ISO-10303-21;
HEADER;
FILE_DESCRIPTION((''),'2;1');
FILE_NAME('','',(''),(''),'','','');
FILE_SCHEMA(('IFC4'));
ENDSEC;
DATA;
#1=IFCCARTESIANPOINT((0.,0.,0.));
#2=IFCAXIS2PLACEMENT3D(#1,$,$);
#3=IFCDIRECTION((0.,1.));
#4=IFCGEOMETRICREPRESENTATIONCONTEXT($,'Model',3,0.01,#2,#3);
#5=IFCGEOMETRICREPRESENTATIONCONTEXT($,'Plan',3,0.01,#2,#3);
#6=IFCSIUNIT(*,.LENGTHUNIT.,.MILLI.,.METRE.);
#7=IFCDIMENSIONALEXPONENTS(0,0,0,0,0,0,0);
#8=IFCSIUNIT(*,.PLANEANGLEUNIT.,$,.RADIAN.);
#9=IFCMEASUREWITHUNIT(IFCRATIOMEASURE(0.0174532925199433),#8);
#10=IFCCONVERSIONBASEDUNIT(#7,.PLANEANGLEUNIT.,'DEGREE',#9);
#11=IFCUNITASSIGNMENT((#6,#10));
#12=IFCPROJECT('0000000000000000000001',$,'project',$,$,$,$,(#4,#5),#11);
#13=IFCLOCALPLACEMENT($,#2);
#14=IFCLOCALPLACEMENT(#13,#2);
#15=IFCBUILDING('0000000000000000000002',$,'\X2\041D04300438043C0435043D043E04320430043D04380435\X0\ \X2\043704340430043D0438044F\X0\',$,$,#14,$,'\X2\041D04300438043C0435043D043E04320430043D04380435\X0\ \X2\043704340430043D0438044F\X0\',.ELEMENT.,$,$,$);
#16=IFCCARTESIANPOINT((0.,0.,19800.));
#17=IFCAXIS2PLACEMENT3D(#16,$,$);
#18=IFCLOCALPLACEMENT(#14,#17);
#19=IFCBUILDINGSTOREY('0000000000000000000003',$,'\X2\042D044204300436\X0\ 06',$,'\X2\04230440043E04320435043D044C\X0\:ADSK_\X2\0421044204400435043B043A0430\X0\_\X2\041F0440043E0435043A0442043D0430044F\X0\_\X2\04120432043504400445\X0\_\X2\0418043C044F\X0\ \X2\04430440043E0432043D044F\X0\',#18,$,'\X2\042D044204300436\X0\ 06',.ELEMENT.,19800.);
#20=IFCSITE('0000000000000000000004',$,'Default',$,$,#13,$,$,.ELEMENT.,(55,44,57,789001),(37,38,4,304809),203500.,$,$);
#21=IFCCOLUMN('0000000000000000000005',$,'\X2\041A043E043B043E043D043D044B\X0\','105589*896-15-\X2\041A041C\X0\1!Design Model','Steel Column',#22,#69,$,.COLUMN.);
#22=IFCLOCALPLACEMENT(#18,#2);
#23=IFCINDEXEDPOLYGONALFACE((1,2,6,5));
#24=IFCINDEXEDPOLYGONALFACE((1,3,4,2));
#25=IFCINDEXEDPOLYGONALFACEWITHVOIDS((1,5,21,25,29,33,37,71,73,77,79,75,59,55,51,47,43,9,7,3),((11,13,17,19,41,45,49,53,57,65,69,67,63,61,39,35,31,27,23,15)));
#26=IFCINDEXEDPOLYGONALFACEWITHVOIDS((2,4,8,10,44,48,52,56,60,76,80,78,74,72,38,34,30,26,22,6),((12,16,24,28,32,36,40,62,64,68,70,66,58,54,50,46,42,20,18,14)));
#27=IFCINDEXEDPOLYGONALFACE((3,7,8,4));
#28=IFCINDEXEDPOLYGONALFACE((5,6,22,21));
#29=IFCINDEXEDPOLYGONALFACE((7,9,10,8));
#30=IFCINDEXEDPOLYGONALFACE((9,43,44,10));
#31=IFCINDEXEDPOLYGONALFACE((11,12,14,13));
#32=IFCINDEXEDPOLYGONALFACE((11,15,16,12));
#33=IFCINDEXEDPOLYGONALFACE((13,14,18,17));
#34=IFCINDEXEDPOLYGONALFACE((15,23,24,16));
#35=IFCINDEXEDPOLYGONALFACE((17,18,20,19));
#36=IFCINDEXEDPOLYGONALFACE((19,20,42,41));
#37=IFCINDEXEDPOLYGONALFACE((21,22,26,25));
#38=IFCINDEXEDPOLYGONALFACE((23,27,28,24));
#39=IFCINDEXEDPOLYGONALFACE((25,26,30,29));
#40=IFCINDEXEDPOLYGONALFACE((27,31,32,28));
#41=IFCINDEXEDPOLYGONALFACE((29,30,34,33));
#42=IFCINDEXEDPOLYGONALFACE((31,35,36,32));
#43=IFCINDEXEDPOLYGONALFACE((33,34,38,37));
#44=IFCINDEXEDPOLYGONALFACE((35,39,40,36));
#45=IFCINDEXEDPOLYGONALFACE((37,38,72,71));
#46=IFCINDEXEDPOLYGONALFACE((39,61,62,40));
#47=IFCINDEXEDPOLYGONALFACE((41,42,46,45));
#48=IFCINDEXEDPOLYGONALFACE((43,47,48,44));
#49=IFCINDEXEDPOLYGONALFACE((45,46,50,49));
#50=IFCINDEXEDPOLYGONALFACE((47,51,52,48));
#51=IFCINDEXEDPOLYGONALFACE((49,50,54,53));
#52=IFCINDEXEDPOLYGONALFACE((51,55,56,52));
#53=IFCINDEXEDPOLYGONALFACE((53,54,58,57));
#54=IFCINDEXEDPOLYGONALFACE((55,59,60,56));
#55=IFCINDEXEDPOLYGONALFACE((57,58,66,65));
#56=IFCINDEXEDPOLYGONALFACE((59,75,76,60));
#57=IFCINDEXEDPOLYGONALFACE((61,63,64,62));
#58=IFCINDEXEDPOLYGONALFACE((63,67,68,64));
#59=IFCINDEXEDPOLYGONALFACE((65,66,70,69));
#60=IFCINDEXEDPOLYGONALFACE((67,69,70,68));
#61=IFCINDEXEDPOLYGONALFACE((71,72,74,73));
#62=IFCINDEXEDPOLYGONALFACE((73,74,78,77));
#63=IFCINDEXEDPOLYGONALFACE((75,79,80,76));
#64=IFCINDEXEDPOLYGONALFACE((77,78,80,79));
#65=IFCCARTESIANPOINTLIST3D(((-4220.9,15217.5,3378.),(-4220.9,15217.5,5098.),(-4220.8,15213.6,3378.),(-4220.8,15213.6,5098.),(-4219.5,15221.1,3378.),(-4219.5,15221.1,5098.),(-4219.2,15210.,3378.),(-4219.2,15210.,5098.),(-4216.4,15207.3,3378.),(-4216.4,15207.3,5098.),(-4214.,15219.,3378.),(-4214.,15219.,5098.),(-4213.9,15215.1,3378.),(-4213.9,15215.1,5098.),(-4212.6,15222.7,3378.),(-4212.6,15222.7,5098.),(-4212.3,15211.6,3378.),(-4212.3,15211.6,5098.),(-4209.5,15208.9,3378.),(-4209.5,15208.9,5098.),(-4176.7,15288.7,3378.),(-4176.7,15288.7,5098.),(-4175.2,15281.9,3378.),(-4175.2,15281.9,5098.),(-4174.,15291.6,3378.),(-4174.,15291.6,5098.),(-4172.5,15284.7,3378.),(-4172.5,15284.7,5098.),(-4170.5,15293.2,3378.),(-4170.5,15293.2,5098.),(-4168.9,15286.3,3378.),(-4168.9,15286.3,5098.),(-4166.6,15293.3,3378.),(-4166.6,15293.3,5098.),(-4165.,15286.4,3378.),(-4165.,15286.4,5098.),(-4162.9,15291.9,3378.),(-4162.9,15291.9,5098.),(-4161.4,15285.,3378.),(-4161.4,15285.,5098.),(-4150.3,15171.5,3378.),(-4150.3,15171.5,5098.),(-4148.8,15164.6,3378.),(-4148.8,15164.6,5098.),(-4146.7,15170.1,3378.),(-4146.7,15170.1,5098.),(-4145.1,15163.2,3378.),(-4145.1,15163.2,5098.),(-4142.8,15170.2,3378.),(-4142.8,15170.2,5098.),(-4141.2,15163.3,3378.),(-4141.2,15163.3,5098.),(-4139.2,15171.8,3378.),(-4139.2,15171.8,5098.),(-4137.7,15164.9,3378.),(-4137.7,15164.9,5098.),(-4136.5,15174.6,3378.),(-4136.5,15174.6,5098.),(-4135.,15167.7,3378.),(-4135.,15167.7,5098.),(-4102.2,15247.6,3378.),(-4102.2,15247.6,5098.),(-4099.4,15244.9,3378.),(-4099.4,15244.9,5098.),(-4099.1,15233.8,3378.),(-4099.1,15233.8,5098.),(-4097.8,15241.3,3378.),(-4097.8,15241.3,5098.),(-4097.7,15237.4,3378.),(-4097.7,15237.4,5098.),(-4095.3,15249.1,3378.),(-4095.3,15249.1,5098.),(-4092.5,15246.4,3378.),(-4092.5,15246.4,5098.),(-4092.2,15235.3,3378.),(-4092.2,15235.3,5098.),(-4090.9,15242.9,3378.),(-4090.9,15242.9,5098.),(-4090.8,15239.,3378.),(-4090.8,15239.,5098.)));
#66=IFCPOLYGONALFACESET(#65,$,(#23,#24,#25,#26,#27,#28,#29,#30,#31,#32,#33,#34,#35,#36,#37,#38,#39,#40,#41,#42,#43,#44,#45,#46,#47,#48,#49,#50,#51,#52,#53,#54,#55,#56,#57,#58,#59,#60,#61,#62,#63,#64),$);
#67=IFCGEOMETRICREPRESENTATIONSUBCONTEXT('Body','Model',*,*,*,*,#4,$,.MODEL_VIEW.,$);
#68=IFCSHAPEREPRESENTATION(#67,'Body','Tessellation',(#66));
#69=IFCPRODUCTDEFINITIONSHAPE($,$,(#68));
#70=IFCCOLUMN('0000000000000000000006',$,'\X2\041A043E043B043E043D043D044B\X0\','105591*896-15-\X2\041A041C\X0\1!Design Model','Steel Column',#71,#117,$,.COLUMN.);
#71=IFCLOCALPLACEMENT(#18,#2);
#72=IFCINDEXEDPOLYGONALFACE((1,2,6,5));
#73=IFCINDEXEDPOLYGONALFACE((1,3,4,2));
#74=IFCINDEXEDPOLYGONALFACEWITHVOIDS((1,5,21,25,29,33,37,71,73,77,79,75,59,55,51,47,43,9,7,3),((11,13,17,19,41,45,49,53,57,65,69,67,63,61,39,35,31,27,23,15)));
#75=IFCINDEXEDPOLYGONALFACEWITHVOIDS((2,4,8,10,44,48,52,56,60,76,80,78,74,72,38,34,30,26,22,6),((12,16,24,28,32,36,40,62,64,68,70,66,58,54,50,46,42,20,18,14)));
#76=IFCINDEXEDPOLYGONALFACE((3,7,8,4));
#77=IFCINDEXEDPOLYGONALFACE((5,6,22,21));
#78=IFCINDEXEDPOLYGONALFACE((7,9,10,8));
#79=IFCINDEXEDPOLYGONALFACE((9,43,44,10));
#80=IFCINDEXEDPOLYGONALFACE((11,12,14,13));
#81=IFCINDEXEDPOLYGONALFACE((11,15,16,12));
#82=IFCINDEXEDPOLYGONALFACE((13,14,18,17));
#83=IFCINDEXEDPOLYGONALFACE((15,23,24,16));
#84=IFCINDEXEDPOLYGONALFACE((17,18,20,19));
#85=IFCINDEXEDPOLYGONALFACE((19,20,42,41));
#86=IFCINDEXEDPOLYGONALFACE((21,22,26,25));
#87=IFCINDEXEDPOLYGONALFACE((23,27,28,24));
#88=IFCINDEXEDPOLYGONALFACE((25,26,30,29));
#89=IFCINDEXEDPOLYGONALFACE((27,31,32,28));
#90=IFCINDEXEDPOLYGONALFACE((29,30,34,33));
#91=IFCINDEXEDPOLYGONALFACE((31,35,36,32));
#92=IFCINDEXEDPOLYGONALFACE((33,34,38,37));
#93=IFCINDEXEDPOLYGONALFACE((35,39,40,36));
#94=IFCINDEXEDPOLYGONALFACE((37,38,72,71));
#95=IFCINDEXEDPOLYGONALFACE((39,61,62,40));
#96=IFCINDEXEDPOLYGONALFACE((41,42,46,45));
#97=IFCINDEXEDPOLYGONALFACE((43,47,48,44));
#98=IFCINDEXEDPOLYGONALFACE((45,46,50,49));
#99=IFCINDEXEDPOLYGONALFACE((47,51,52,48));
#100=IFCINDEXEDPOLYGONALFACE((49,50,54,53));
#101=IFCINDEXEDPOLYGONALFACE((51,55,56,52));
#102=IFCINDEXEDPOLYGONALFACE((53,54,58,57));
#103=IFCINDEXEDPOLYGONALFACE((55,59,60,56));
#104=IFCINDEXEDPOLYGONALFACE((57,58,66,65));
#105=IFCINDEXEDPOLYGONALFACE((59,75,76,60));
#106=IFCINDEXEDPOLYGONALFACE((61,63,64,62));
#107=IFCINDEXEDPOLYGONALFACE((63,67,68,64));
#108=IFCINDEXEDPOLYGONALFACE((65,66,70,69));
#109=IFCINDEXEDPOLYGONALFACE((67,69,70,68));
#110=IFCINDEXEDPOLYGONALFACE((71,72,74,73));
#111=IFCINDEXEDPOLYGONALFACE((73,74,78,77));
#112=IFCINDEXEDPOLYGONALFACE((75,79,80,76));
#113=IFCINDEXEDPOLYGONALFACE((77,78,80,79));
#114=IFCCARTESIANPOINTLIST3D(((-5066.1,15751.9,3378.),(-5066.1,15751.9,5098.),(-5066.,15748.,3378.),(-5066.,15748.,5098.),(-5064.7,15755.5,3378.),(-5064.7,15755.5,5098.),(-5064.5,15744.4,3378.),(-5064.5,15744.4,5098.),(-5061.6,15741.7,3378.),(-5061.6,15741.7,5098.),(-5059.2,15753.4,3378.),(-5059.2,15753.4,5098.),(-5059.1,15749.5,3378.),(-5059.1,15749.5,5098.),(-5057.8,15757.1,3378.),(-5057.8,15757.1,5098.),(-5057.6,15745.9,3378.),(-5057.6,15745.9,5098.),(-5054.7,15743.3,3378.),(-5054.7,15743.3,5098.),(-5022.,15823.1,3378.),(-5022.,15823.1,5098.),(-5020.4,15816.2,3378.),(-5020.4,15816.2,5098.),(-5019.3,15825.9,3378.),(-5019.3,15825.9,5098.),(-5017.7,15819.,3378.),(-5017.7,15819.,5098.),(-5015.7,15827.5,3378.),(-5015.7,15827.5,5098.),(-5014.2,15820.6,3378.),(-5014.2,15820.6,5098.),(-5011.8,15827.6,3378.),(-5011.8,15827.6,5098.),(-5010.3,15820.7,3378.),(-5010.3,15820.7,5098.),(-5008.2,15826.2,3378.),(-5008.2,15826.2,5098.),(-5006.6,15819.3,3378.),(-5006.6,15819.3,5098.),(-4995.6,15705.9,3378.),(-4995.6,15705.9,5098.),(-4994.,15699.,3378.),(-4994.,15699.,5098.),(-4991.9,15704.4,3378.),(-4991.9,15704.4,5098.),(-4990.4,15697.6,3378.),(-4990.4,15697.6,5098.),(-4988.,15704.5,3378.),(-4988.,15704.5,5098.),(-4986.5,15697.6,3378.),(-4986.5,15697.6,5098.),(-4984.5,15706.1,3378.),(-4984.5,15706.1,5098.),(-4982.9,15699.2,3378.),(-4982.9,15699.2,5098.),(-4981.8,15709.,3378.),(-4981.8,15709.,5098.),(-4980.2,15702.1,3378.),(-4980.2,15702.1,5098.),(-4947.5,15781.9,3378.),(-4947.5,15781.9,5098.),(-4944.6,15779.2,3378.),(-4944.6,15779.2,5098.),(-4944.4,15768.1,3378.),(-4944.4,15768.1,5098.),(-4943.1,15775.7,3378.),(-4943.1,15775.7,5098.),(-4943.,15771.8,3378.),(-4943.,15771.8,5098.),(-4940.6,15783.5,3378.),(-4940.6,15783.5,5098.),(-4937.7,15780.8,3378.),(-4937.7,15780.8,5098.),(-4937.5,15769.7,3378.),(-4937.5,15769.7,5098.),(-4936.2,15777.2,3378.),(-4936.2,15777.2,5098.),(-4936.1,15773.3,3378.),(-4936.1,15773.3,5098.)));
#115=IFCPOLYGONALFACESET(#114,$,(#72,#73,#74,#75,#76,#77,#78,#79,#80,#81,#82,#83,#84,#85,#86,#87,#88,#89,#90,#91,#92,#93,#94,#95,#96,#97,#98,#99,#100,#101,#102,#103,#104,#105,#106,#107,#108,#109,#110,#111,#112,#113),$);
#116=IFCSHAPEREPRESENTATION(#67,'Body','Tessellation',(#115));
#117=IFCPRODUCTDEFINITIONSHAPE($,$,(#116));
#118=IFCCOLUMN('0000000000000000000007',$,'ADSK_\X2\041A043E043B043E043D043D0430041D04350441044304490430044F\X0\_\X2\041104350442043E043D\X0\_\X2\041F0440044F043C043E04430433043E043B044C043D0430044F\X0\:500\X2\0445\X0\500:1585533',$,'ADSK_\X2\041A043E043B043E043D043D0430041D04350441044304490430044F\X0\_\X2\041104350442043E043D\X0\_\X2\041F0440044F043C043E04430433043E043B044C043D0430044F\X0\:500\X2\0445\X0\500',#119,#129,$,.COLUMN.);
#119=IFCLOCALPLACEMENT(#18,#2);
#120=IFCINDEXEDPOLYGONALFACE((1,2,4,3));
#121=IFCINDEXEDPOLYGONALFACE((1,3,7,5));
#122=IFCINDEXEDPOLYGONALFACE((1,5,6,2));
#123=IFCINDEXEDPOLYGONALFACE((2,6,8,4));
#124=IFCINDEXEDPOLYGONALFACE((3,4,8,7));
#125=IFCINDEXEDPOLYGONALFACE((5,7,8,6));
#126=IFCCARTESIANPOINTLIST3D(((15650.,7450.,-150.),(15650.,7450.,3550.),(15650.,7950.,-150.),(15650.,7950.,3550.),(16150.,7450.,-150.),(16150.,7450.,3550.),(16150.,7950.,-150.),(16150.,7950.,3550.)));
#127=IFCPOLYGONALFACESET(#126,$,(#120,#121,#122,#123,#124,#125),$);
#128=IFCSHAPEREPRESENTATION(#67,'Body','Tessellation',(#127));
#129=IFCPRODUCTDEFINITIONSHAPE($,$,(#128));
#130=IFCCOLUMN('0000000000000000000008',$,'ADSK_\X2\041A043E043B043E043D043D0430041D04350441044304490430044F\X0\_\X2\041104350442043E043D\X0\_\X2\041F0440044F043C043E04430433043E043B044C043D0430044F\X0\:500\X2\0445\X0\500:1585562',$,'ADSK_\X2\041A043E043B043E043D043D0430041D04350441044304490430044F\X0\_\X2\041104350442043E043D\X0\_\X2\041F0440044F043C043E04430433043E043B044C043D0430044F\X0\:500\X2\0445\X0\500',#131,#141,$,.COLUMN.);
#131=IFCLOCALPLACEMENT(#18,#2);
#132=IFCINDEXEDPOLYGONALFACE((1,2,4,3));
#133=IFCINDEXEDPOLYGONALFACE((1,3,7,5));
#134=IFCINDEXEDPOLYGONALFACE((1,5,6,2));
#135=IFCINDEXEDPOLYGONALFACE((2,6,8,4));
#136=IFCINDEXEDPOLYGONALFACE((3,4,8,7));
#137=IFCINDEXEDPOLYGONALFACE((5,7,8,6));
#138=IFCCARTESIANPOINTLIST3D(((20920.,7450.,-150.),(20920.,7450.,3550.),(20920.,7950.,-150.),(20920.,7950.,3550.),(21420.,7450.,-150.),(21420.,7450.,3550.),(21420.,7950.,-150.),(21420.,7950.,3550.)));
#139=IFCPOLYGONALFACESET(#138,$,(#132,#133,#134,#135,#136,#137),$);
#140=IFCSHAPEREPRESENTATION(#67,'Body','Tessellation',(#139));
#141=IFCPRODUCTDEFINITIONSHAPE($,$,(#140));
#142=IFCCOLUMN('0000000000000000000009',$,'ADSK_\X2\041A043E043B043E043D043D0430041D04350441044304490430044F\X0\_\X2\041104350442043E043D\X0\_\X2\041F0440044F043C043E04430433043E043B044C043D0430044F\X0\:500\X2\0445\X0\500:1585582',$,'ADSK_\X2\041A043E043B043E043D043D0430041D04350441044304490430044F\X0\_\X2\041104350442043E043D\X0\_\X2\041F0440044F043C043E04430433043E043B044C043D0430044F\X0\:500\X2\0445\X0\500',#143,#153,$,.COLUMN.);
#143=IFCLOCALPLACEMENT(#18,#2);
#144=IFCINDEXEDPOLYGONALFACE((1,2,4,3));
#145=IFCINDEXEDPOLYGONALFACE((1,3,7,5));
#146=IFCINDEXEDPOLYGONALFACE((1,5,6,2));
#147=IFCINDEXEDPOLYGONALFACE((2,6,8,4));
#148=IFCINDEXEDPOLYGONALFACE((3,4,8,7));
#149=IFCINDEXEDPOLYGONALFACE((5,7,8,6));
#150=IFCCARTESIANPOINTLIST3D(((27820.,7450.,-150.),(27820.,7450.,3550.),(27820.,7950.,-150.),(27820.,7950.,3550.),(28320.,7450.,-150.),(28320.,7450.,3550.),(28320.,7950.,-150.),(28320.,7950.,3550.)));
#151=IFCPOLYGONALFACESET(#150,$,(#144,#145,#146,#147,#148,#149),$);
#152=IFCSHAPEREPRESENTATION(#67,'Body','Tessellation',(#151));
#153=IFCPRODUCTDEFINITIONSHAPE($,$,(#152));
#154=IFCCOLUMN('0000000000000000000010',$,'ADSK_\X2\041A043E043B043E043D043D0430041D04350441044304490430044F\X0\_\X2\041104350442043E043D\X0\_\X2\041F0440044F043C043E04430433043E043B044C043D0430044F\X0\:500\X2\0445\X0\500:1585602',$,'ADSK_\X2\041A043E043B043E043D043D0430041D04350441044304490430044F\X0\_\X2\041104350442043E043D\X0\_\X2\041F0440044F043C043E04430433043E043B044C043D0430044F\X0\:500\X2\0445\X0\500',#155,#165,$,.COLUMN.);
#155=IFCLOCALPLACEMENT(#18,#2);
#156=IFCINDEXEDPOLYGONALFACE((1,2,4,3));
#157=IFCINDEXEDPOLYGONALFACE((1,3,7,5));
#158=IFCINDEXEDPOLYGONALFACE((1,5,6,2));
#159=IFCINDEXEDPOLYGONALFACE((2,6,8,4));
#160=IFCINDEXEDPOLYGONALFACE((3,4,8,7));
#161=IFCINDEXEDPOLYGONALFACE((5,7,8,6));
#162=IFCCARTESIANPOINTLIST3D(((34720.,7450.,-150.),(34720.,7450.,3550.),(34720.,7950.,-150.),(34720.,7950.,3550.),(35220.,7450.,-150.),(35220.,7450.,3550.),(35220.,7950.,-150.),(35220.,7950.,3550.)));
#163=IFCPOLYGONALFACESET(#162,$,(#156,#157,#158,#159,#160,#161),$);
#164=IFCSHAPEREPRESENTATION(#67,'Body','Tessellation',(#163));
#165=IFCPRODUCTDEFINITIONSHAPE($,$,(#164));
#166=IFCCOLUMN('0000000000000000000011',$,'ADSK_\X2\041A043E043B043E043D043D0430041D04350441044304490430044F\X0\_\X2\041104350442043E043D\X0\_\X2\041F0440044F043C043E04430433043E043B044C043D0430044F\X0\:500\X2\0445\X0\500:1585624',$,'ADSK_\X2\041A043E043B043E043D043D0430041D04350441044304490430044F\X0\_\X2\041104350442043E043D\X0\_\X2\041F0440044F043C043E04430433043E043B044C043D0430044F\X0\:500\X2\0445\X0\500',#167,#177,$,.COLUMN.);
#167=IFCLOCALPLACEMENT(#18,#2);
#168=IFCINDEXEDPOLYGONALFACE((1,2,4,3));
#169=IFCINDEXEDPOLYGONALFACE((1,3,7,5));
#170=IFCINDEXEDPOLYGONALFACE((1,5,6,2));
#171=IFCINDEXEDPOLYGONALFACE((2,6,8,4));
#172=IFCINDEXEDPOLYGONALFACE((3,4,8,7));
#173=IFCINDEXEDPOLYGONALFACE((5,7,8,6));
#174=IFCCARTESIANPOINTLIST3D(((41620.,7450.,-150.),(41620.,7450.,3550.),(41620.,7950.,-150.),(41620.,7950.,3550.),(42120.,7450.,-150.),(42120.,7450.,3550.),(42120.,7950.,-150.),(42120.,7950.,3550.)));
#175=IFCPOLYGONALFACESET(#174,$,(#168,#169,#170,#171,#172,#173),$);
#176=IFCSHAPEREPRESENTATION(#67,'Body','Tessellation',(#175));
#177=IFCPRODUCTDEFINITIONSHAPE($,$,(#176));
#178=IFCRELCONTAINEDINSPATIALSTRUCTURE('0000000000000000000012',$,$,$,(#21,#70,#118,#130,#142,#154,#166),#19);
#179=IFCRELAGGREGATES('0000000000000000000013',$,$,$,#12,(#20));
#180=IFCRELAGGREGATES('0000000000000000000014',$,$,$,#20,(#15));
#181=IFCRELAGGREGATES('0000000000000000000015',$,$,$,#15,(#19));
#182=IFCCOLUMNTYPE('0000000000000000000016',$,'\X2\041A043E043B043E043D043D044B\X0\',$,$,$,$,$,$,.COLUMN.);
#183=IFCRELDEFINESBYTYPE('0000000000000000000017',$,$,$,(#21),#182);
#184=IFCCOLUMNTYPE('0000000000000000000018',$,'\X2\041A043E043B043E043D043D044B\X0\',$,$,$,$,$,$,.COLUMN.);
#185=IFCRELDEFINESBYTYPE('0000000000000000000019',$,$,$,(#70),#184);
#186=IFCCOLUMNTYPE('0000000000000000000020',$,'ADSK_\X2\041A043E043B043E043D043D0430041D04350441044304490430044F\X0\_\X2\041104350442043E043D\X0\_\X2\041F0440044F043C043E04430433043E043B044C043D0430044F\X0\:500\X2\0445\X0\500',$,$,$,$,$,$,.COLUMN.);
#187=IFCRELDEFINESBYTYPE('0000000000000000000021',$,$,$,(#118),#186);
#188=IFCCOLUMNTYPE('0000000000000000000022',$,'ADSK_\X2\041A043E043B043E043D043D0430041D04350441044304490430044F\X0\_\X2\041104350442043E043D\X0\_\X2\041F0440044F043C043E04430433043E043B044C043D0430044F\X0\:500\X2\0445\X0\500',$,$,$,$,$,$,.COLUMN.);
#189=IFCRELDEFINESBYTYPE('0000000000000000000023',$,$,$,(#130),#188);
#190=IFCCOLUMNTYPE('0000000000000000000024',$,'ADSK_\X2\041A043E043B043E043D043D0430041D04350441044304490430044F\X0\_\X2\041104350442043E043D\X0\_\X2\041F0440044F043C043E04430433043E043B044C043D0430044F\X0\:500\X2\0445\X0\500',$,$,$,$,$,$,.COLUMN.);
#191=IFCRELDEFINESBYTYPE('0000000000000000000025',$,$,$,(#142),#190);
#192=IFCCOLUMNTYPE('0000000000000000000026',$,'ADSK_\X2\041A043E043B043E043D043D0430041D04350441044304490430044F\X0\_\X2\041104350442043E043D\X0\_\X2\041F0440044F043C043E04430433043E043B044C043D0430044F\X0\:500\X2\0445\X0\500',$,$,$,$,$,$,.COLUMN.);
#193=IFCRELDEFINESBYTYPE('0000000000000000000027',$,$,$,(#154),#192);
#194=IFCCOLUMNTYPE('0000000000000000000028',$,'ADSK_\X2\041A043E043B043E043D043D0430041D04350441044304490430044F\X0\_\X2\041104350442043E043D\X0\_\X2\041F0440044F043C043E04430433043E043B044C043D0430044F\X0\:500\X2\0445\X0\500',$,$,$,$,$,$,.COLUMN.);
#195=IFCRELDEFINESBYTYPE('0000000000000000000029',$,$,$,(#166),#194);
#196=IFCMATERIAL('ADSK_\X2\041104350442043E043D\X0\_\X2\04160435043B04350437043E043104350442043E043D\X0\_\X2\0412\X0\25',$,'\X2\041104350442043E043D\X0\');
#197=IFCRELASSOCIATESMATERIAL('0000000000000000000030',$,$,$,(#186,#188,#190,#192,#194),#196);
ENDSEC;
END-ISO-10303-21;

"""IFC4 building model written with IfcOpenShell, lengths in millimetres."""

from ifc_helpers import new_model, entity, si_unit, converted_unit, direction, frame, origin, place, context, subcontext, project, spatial, indexed_curve, outline, extrude, source, transform, mapped, material, type_object, type_shapes, element, save


model = new_model("IFC4")

# Units and contexts
model_context = context("Model", 3, precision=0.01, world=origin(), true_north=direction((0.0, 1.0)))
plan_context = context("Plan", 3, precision=0.01, world=origin(), true_north=direction((0.0, 1.0)))
body_context = subcontext(model_context, "Body", "Model", "MODEL_VIEW")
ifc_project = project(units=[si_unit("LENGTHUNIT", "METRE", prefix="MILLI"), converted_unit("PLANEANGLEUNIT", "DEGREE", entity("IfcRatioMeasure", 0.0174532925199433), si_unit("PLANEANGLEUNIT", "RADIAN"), dimensions=[0, 0, 0, 0, 0, 0, 0])], contexts=[model_context, plan_context])

# Site, building, storey
site_placement = place(None, origin())
site = spatial("IfcSite", under=ifc_project, at=site_placement, Name="Default", CompositionType="ELEMENT", RefLatitude=(55, 44, 57, 789001), RefLongitude=(37, 38, 4, 304809), RefElevation=203500.0)
building_placement = place(site_placement, origin())
building = spatial("IfcBuilding", under=site, at=building_placement, Name="Наименование здания", LongName="Наименование здания", CompositionType="ELEMENT")
storey_placement = place(building_placement, frame((0.0, 0.0, 19800.0)))
storey = spatial("IfcBuildingStorey", under=building, at=storey_placement, Name="Этаж 06", ObjectType="Уровень:ADSK_Стрелка_Проектная_Вверх_Имя уровня", LongName="Этаж 06", CompositionType="ELEMENT", Elevation=19800.0)

# Columns
placement_1 = place(storey_placement, origin())
column_type_1 = type_object("IfcColumnType", Name="Колонны", PredefinedType="COLUMN")
element("IfcColumn", 1, at=placement_1, inside=storey, type_object=column_type_1, Name="Колонны", Description="105589*896-15-КМ1!Design Model", ObjectType="Steel Column", PredefinedType="COLUMN", context=body_context, shape_type="SweptSolid", body=[
    extrude(outline(indexed_curve([(29.5, -56.8), (33.4, -56.8), (37.0, -55.3), (39.7, -52.6), (41.2, -49.0), (56.8, 29.5), (56.8, 33.4), (55.3, 37.0), (52.6, 39.7), (49.0, 41.2), (-29.5, 56.8), (-33.4, 56.8), (-37.0, 55.3), (-39.7, 52.6), (-41.2, 49.0), (-56.8, -29.5), (-56.8, -33.4), (-55.3, -37.0), (-52.6, -39.7), (-49.0, -41.2), (29.5, -56.8)], self_intersect=False), holes=[indexed_curve([(-43.1, -37.3), (-46.7, -35.8), (-49.5, -33.1), (-51.0, -29.5), (-51.0, -25.5), (-37.3, 43.1), (-35.8, 46.7), (-33.1, 49.5), (-29.5, 51.0), (-25.5, 51.0), (43.1, 37.3), (46.7, 35.8), (49.5, 33.1), (51.0, 29.5), (51.0, 25.5), (37.3, -43.1), (35.8, -46.7), (33.1, -49.5), (29.5, -51.0), (25.5, -51.0), (-43.1, -37.3)], self_intersect=False)]), frame((-4155.9, 15228.2, 3378.0), z_axis=(0.0, 0.0, 1.0), x_axis=(-0.933263, 0.359194, 0.0)), (0.0, 0.0, 1.0), 1720.0),
])
column_type_2 = type_object("IfcColumnType", Name="Колонны", PredefinedType="COLUMN")
element("IfcColumn", 2, at=placement_1, inside=storey, type_object=column_type_2, Name="Колонны", Description="105591*896-15-КМ1!Design Model", ObjectType="Steel Column", PredefinedType="COLUMN", context=body_context, shape_type="SweptSolid", body=[
    extrude(outline(indexed_curve([(29.5, -56.8), (33.4, -56.8), (37.0, -55.3), (39.7, -52.6), (41.2, -49.0), (56.8, 29.5), (56.8, 33.4), (55.3, 37.0), (52.6, 39.7), (49.0, 41.2), (-29.5, 56.8), (-33.4, 56.8), (-37.0, 55.3), (-39.7, 52.6), (-41.2, 49.0), (-56.8, -29.5), (-56.8, -33.4), (-55.3, -37.0), (-52.6, -39.7), (-49.0, -41.2), (29.5, -56.8)], self_intersect=False), holes=[indexed_curve([(-43.1, -37.3), (-46.7, -35.8), (-49.5, -33.1), (-51.0, -29.5), (-51.0, -25.5), (-37.3, 43.1), (-35.8, 46.7), (-33.1, 49.5), (-29.5, 51.0), (-25.5, 51.0), (43.1, 37.3), (46.7, 35.8), (49.5, 33.1), (51.0, 29.5), (51.0, 25.5), (37.3, -43.1), (35.8, -46.7), (33.1, -49.5), (29.5, -51.0), (25.5, -51.0), (-43.1, -37.3)], self_intersect=False)]), frame((-5001.1, 15762.6, 3378.0), z_axis=(0.0, 0.0, 1.0), x_axis=(-0.933263, 0.359194, 0.0)), (0.0, 0.0, 1.0), 1720.0),
])
ifc_material = material(Name="ADSK_Бетон_Железобетон_В25", Category="Бетон")
column_type_3 = type_object("IfcColumnType", Name="ADSK_КолоннаНесущая_Бетон_Прямоугольная:500х500", PredefinedType="COLUMN", material=ifc_material)
shared_shape_1 = source(origin(), body_context, "Body", "SweptSolid", [
    extrude(outline(indexed_curve([(-250.0, -250.0), (250.0, -250.0), (250.0, 250.0), (-250.0, 250.0), (-250.0, -250.0)], self_intersect=False)), frame((15900.0, 7700.0, 19650.0), z_axis=(0.0, 0.0, 1.0), x_axis=(0.0, -1.0, 0.0)), (0.0, 0.0, 1.0), 3700.0),
])
type_shapes(column_type_3, [shared_shape_1])
placement_2 = place(storey_placement, frame((0.0, 0.0, -19800.0)))
element("IfcColumn", 3, at=placement_2, inside=storey, type_object=column_type_3, Name="ADSK_КолоннаНесущая_Бетон_Прямоугольная:500х500:1585533", ObjectType="ADSK_КолоннаНесущая_Бетон_Прямоугольная:500х500", PredefinedType="COLUMN", context=body_context, shape_type="MappedRepresentation", body=[
    mapped(shared_shape_1, transform((0.0, 0.0, 0.0), scale=1.0)),
])
column_type_4 = type_object("IfcColumnType", Name="ADSK_КолоннаНесущая_Бетон_Прямоугольная:500х500", PredefinedType="COLUMN", material=ifc_material)
shared_shape_2 = source(origin(), body_context, "Body", "SweptSolid", [
    extrude(outline(indexed_curve([(-250.0, -250.0), (250.0, -250.0), (250.0, 250.0), (-250.0, 250.0), (-250.0, -250.0)], self_intersect=False)), frame((21170.0, 7700.0, 19650.0), z_axis=(0.0, 0.0, 1.0), x_axis=(0.0, -1.0, 0.0)), (0.0, 0.0, 1.0), 3700.0),
])
type_shapes(column_type_4, [shared_shape_2])
element("IfcColumn", 4, at=placement_2, inside=storey, type_object=column_type_4, Name="ADSK_КолоннаНесущая_Бетон_Прямоугольная:500х500:1585562", ObjectType="ADSK_КолоннаНесущая_Бетон_Прямоугольная:500х500", PredefinedType="COLUMN", context=body_context, shape_type="MappedRepresentation", body=[
    mapped(shared_shape_2, transform((0.0, 0.0, 0.0), scale=1.0)),
])
column_type_5 = type_object("IfcColumnType", Name="ADSK_КолоннаНесущая_Бетон_Прямоугольная:500х500", PredefinedType="COLUMN", material=ifc_material)
shared_shape_3 = source(origin(), body_context, "Body", "SweptSolid", [
    extrude(outline(indexed_curve([(-250.0, -250.0), (250.0, -250.0), (250.0, 250.0), (-250.0, 250.0), (-250.0, -250.0)], self_intersect=False)), frame((28070.0, 7700.0, 19650.0), z_axis=(0.0, 0.0, 1.0), x_axis=(0.0, -1.0, 0.0)), (0.0, 0.0, 1.0), 3700.0),
])
type_shapes(column_type_5, [shared_shape_3])
element("IfcColumn", 5, at=placement_2, inside=storey, type_object=column_type_5, Name="ADSK_КолоннаНесущая_Бетон_Прямоугольная:500х500:1585582", ObjectType="ADSK_КолоннаНесущая_Бетон_Прямоугольная:500х500", PredefinedType="COLUMN", context=body_context, shape_type="MappedRepresentation", body=[
    mapped(shared_shape_3, transform((0.0, 0.0, 0.0), scale=1.0)),
])
column_type_6 = type_object("IfcColumnType", Name="ADSK_КолоннаНесущая_Бетон_Прямоугольная:500х500", PredefinedType="COLUMN", material=ifc_material)
shared_shape_4 = source(origin(), body_context, "Body", "SweptSolid", [
    extrude(outline(indexed_curve([(-250.0, -250.0), (250.0, -250.0), (250.0, 250.0), (-250.0, 250.0), (-250.0, -250.0)], self_intersect=False)), frame((34970.0, 7700.0, 19650.0), z_axis=(0.0, 0.0, 1.0), x_axis=(0.0, -1.0, 0.0)), (0.0, 0.0, 1.0), 3700.0),
])
type_shapes(column_type_6, [shared_shape_4])
element("IfcColumn", 6, at=placement_2, inside=storey, type_object=column_type_6, Name="ADSK_КолоннаНесущая_Бетон_Прямоугольная:500х500:1585602", ObjectType="ADSK_КолоннаНесущая_Бетон_Прямоугольная:500х500", PredefinedType="COLUMN", context=body_context, shape_type="MappedRepresentation", body=[
    mapped(shared_shape_4, transform((0.0, 0.0, 0.0), scale=1.0)),
])
column_type_7 = type_object("IfcColumnType", Name="ADSK_КолоннаНесущая_Бетон_Прямоугольная:500х500", PredefinedType="COLUMN", material=ifc_material)
shared_shape_5 = source(origin(), body_context, "Body", "SweptSolid", [
    extrude(outline(indexed_curve([(-250.0, -250.0), (250.0, -250.0), (250.0, 250.0), (-250.0, 250.0), (-250.0, -250.0)], self_intersect=False)), frame((41870.0, 7700.0, 19650.0), z_axis=(0.0, 0.0, 1.0), x_axis=(0.0, -1.0, 0.0)), (0.0, 0.0, 1.0), 3700.0),
])
type_shapes(column_type_7, [shared_shape_5])
element("IfcColumn", 7, at=placement_2, inside=storey, type_object=column_type_7, Name="ADSK_КолоннаНесущая_Бетон_Прямоугольная:500х500:1585624", ObjectType="ADSK_КолоннаНесущая_Бетон_Прямоугольная:500х500", PredefinedType="COLUMN", context=body_context, shape_type="MappedRepresentation", body=[
    mapped(shared_shape_5, transform((0.0, 0.0, 0.0), scale=1.0)),
])

save(model, "model.ifc")
